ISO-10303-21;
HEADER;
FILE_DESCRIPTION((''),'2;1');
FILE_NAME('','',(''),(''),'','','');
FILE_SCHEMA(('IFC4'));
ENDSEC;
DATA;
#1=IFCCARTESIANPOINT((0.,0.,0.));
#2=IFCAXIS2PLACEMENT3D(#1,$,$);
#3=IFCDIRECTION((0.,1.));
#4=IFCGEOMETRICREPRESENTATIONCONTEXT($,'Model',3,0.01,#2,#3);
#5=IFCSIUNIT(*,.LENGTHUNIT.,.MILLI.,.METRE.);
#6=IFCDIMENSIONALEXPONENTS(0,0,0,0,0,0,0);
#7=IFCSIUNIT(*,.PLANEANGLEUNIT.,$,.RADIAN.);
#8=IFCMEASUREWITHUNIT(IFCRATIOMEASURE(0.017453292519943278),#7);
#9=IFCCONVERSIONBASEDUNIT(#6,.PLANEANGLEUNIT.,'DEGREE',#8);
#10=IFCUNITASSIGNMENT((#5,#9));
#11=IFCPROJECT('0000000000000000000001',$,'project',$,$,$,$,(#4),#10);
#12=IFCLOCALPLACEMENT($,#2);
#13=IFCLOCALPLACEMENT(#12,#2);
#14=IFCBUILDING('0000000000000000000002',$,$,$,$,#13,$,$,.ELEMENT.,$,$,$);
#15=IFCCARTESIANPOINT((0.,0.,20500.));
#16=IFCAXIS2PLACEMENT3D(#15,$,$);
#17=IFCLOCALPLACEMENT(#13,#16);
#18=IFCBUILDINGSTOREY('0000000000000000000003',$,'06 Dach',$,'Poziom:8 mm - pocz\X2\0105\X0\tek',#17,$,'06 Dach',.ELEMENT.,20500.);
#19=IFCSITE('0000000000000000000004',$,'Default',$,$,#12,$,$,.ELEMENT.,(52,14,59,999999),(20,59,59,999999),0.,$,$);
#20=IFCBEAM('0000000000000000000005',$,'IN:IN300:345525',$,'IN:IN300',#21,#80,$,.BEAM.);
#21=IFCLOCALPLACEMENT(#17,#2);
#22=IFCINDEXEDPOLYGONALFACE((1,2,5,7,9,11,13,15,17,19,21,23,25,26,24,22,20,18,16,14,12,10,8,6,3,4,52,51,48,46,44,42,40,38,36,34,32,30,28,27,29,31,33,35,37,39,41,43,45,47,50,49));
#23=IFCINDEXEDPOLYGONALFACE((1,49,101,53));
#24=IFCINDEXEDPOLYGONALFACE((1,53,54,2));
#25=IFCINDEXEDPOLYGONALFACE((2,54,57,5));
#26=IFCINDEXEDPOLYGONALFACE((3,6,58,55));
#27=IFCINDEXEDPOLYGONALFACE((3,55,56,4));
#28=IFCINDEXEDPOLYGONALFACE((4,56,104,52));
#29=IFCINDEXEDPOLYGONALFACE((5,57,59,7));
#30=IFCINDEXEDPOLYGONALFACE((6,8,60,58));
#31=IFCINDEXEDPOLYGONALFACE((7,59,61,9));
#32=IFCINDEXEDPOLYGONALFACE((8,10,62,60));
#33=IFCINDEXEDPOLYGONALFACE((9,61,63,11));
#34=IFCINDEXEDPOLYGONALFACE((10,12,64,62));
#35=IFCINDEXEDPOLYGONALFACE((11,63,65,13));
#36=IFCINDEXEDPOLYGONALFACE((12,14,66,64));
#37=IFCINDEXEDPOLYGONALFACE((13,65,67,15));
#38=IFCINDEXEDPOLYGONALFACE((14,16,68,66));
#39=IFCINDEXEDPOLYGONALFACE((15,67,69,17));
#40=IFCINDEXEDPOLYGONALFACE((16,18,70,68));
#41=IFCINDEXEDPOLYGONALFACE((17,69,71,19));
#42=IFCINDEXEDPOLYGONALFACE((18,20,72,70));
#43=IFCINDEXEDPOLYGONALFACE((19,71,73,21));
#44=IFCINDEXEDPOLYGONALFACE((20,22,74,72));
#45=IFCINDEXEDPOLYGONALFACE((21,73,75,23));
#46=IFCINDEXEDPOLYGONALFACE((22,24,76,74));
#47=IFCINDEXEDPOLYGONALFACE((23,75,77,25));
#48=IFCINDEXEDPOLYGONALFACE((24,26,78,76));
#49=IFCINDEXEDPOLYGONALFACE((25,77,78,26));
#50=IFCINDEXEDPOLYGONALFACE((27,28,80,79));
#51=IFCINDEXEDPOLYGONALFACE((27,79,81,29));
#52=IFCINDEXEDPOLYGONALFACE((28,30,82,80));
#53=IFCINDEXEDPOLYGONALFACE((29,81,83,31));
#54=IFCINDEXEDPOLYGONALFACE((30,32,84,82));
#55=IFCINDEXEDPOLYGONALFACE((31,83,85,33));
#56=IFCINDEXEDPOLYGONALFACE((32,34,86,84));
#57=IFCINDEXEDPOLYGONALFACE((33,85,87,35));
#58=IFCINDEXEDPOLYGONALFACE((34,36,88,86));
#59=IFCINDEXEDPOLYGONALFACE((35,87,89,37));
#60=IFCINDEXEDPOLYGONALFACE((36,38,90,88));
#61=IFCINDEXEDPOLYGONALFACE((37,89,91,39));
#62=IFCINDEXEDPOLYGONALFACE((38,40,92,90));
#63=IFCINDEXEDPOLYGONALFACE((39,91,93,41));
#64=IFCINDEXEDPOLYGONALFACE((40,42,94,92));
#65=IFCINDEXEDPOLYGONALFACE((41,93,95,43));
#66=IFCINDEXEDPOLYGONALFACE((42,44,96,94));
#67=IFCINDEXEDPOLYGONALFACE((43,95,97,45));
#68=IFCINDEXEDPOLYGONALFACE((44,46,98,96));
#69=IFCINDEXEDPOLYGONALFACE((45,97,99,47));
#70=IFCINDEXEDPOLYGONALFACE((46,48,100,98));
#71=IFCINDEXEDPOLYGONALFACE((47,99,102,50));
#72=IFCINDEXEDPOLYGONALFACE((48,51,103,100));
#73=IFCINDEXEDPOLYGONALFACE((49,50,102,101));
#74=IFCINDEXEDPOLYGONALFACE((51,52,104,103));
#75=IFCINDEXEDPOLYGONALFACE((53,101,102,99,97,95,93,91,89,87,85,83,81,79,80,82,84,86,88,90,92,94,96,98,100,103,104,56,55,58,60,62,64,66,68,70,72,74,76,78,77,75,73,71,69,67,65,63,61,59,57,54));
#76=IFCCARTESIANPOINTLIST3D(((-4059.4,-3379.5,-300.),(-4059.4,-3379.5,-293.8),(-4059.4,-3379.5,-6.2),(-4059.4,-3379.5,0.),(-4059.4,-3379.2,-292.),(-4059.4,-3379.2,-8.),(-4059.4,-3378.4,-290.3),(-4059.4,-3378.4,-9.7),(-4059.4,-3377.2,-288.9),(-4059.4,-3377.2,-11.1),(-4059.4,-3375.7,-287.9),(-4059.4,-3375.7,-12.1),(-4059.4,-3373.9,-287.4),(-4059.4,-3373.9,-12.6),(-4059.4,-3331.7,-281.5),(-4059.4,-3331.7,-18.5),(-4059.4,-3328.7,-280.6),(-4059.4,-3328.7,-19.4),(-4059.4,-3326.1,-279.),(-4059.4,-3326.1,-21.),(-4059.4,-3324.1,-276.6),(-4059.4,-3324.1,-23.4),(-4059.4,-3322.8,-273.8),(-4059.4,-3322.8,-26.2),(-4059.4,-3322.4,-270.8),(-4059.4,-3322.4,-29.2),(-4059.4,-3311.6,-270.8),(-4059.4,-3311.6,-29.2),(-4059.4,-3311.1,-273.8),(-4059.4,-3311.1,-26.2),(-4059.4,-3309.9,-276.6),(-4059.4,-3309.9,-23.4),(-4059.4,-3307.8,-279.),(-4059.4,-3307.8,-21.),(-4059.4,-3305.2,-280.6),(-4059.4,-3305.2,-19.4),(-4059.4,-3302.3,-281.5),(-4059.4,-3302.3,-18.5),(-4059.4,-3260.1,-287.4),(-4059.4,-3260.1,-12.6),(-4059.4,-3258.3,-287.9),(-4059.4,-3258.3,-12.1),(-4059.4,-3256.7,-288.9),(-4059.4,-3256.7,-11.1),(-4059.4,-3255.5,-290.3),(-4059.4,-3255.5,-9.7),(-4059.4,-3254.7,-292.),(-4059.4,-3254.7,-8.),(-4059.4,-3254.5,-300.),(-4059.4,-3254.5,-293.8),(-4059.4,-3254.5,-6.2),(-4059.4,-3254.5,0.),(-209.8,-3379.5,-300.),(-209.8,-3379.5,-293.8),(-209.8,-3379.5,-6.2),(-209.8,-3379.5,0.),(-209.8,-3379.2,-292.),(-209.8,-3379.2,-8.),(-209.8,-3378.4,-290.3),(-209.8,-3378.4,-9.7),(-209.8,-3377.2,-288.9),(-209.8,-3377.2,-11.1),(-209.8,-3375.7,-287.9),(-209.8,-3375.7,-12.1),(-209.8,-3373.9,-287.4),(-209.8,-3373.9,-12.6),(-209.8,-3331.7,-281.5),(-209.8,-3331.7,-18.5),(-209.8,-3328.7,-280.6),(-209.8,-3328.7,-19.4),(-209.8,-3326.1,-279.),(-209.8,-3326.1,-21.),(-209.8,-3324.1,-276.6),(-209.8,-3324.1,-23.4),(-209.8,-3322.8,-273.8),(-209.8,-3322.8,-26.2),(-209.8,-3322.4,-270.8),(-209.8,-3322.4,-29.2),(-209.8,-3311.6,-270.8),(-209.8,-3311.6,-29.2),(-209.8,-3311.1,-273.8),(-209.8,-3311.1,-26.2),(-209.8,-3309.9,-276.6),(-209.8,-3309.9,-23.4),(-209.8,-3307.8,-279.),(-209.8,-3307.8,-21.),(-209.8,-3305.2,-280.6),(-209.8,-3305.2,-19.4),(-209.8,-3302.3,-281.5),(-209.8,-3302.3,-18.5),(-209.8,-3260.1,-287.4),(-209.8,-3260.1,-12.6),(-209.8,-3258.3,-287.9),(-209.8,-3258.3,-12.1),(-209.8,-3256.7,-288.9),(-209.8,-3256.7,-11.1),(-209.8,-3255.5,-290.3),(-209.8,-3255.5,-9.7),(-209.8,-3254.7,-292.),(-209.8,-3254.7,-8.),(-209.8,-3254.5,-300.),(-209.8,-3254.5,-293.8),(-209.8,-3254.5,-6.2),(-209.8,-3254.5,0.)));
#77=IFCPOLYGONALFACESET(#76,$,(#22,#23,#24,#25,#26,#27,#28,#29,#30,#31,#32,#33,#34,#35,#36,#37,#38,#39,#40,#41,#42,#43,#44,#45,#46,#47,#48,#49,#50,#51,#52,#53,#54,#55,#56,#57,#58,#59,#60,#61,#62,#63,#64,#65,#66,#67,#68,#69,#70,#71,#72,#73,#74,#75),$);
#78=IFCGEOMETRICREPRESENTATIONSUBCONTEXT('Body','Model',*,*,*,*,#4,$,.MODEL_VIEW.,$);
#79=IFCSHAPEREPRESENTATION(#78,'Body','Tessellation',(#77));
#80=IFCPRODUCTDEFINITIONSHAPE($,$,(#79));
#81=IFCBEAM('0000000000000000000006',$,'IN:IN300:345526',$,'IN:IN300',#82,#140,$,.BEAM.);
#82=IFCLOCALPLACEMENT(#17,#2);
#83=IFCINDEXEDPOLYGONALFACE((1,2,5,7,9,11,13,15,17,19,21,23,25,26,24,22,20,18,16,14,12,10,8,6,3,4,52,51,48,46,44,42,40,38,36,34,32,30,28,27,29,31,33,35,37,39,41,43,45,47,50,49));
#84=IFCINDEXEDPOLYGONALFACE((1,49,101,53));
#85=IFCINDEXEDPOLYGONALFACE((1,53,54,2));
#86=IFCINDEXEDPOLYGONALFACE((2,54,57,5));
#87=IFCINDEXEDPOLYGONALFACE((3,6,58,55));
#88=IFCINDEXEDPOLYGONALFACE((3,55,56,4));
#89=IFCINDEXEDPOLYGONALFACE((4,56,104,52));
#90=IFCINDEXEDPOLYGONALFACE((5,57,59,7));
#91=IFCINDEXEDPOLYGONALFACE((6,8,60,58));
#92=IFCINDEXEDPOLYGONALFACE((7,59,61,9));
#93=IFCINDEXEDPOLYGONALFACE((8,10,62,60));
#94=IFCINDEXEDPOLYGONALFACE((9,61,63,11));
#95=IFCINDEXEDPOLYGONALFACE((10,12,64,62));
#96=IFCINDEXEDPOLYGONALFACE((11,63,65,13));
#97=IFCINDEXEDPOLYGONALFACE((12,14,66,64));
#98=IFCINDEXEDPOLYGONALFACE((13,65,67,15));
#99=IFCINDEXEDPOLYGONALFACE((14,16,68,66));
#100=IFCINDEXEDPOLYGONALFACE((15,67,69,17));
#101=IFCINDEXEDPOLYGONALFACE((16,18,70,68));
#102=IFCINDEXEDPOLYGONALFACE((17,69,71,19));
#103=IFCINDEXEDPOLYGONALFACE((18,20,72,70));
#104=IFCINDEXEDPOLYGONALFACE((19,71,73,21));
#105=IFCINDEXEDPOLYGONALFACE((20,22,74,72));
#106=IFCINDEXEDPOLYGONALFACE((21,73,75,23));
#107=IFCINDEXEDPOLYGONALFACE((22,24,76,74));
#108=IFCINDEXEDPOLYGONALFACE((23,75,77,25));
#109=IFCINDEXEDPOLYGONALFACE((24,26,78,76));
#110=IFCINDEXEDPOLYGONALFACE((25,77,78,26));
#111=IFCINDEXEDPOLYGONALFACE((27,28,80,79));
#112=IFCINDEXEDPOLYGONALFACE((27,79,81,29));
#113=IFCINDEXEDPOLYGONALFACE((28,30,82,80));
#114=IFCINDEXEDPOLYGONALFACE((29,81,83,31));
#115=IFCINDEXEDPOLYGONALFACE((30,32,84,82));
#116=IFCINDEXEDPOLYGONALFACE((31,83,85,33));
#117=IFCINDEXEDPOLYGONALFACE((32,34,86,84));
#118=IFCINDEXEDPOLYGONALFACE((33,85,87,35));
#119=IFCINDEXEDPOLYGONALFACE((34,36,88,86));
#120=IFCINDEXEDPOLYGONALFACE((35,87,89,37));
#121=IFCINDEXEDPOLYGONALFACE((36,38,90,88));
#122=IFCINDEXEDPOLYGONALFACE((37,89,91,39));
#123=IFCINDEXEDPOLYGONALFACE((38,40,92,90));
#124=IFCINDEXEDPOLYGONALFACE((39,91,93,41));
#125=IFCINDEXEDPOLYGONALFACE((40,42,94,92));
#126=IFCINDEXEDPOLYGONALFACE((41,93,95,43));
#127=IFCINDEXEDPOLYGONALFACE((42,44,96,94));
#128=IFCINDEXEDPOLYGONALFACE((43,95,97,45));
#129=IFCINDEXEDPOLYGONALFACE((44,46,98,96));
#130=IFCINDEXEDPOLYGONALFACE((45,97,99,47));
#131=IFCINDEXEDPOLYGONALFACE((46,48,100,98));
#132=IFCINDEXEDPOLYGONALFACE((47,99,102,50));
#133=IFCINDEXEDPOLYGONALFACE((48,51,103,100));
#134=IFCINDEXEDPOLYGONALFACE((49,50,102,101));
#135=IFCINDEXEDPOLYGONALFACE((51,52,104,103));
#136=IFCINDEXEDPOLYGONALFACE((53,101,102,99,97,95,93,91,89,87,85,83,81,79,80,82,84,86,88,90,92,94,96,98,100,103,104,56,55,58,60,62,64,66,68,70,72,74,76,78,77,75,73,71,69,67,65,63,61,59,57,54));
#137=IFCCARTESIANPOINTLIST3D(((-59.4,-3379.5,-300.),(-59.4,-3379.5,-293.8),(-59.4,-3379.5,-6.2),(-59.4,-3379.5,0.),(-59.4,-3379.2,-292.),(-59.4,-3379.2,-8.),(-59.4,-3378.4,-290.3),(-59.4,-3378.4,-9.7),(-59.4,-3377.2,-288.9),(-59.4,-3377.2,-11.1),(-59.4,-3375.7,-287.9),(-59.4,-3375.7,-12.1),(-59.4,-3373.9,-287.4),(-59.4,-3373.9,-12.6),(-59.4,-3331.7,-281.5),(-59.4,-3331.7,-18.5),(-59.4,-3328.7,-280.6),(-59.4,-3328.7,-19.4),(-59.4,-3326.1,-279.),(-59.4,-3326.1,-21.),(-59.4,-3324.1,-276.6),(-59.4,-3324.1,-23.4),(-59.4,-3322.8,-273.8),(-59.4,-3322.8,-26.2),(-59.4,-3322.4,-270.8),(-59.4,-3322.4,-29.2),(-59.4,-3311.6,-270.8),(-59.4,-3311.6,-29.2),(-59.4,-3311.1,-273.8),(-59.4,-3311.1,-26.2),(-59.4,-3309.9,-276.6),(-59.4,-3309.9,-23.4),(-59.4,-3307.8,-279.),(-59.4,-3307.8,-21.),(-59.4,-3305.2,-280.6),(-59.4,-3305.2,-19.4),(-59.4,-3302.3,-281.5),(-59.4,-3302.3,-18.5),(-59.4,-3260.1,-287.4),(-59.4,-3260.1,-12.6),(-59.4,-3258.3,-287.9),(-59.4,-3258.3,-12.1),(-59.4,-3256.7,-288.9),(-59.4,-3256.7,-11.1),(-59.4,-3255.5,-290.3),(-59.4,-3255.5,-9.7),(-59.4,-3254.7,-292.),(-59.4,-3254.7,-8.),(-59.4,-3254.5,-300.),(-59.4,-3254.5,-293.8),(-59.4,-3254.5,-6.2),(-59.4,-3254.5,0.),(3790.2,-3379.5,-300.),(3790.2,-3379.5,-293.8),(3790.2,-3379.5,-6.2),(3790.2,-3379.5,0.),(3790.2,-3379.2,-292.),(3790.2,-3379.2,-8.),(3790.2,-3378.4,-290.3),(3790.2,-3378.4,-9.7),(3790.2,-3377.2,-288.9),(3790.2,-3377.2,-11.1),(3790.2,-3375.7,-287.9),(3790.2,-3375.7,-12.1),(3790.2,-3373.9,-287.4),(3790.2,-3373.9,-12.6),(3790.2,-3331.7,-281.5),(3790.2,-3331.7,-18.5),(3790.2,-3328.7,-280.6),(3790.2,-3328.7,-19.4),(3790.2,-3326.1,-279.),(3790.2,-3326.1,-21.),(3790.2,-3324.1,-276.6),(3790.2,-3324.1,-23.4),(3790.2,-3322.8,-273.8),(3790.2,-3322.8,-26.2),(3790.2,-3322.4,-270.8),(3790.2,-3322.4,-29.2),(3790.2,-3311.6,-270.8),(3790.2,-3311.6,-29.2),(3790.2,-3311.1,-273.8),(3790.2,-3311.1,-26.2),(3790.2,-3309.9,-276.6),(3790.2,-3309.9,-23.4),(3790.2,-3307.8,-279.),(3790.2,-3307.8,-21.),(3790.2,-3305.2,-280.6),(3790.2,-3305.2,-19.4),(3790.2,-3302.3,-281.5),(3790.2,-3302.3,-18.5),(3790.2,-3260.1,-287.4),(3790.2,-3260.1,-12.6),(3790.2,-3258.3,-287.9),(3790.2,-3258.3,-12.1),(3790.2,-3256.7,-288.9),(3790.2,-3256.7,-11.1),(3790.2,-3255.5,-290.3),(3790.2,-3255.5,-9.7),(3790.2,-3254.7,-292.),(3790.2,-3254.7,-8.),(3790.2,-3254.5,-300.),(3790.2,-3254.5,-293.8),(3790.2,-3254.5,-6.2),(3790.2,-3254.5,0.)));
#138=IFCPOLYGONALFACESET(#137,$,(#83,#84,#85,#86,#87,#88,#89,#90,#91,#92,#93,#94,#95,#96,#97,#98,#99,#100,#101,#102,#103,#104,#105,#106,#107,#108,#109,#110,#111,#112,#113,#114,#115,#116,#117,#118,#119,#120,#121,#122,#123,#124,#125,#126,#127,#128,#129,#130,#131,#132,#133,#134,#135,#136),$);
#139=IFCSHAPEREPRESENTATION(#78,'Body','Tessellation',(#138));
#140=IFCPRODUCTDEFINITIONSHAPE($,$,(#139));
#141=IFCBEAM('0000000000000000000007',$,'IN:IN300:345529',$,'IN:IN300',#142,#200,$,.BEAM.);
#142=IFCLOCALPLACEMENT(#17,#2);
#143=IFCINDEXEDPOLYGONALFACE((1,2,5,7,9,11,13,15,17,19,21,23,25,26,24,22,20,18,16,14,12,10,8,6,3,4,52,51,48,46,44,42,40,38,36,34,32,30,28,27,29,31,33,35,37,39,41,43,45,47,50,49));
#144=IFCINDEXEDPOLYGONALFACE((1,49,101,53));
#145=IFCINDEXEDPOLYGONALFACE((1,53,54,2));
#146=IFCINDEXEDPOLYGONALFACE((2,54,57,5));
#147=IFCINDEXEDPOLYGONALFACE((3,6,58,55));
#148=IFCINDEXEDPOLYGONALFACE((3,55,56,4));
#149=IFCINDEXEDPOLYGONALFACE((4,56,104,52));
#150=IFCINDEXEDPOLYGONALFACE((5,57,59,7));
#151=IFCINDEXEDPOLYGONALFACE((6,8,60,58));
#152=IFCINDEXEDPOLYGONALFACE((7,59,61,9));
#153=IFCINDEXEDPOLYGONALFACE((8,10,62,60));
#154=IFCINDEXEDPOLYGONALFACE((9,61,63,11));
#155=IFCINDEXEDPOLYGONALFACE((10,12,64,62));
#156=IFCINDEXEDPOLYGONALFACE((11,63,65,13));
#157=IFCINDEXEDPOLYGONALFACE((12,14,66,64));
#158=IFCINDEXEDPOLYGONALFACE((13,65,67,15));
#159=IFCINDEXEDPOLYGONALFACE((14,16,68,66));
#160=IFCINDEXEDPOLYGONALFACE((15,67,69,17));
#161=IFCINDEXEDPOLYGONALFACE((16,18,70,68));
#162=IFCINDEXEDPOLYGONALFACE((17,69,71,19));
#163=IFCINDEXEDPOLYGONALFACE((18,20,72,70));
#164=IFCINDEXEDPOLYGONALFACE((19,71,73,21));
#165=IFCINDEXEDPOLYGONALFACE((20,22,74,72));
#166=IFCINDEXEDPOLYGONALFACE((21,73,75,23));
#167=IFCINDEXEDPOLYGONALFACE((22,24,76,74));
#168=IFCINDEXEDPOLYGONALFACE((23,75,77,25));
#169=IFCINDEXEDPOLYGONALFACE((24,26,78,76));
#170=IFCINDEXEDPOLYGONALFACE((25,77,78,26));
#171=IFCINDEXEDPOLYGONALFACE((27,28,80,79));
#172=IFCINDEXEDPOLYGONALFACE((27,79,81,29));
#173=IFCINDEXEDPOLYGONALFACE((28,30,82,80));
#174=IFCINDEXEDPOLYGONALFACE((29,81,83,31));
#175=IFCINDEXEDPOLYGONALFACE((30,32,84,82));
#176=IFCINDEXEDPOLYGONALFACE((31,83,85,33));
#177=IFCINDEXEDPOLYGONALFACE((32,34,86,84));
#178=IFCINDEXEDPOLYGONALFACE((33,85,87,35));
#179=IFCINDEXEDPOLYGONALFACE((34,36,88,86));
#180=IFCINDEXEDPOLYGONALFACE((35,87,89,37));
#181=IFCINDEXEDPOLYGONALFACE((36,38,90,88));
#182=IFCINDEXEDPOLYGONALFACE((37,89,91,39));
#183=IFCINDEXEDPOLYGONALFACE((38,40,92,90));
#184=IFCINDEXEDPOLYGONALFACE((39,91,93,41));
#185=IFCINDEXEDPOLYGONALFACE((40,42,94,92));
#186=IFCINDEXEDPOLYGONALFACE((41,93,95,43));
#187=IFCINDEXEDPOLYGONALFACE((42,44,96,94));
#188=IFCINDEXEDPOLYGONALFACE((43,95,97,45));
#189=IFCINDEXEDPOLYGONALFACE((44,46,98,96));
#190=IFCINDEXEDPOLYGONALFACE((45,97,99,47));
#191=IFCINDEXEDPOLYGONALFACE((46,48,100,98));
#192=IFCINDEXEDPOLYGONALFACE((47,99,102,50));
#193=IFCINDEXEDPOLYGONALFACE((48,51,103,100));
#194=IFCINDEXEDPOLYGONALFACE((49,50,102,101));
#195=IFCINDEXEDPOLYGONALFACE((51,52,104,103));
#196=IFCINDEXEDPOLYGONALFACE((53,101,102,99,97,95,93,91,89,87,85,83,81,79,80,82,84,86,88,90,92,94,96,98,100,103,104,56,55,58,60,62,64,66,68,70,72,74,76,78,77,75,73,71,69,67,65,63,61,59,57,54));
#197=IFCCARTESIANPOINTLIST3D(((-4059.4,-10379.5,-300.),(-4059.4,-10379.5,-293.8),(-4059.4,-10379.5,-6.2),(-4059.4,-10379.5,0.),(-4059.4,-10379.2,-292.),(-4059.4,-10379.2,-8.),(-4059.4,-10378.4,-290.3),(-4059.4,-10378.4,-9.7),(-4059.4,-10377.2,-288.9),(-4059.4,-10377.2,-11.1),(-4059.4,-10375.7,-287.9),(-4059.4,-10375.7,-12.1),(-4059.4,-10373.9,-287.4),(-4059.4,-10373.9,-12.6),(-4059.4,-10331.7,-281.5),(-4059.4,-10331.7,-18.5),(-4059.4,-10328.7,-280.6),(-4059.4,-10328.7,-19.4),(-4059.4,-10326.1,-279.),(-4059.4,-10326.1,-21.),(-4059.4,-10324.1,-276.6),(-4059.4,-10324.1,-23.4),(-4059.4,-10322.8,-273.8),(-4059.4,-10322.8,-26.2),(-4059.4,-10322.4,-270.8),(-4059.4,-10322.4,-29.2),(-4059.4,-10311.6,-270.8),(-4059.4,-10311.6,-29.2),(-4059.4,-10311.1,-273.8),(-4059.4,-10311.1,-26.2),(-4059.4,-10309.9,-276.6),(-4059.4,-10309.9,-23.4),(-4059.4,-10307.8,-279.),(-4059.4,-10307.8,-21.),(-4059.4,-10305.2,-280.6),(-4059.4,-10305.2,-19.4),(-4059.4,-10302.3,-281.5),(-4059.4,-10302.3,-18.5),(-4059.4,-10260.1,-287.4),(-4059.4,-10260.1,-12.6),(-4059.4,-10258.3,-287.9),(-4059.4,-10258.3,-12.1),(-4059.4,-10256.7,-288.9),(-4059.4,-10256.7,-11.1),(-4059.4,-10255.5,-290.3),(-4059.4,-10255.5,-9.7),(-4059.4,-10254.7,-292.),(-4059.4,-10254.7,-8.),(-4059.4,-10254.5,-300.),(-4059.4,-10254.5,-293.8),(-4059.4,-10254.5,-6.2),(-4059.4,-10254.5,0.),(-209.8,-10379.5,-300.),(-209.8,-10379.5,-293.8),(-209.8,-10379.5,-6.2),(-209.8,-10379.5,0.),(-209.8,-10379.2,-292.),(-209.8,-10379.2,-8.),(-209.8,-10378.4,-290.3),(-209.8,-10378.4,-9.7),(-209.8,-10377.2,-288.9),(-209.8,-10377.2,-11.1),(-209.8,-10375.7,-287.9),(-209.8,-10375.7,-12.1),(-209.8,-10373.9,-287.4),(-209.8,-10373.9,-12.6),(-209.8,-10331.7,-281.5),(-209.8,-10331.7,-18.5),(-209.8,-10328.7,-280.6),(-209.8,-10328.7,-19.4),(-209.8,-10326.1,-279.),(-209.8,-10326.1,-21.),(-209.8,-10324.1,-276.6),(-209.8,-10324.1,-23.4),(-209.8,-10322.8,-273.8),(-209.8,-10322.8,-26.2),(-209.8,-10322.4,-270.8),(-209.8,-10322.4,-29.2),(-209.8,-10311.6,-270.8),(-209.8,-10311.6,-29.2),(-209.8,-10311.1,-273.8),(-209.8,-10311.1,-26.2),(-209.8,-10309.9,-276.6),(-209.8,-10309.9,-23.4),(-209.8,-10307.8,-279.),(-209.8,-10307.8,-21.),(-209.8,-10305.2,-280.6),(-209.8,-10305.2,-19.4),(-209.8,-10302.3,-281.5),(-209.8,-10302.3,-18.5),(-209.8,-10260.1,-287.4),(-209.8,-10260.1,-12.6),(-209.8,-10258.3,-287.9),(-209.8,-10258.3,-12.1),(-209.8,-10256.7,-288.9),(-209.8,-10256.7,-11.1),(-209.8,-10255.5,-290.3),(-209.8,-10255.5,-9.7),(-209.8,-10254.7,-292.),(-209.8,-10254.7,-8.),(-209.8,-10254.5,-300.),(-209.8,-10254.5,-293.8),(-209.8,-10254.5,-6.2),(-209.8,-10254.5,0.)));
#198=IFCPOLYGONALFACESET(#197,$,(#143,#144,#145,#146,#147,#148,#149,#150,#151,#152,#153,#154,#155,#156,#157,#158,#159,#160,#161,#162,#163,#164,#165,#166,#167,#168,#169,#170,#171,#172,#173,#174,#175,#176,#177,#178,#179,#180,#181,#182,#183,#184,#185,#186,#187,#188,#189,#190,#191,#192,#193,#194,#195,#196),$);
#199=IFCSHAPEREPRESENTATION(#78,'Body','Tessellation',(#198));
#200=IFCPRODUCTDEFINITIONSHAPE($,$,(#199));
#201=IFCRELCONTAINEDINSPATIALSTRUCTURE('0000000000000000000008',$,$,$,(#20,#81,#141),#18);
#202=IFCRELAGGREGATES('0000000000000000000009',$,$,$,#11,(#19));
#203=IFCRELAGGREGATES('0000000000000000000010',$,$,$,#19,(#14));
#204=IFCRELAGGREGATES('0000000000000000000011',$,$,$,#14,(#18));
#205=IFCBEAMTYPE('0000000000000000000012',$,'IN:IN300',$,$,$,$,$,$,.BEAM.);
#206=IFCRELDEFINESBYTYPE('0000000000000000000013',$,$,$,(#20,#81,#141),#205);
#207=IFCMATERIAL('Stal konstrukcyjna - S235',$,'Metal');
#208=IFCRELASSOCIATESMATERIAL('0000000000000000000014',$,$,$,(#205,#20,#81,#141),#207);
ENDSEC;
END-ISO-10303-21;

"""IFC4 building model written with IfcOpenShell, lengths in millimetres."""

from ifc_helpers import new_model, entity, si_unit, converted_unit, direction, frame, origin, place, context, subcontext, project, spatial, line, arc, indexed_curve, outline, extrude, source, transform, mapped, material, type_object, type_shapes, element, save


model = new_model("IFC4")

# Units and contexts
model_context = context("Model", 3, precision=0.01, world=origin(), true_north=direction((0.0, 1.0)))
body_context = subcontext(model_context, "Body", "Model", "MODEL_VIEW")
ifc_project = project(units=[si_unit("LENGTHUNIT", "METRE", prefix="MILLI"), converted_unit("PLANEANGLEUNIT", "DEGREE", entity("IfcRatioMeasure", 0.017453292519943278), si_unit("PLANEANGLEUNIT", "RADIAN"), dimensions=[0, 0, 0, 0, 0, 0, 0])], contexts=[model_context])

# Site, building, storey
site_placement = place(None, origin())
site = spatial("IfcSite", under=ifc_project, at=site_placement, Name="Default", CompositionType="ELEMENT", RefLatitude=(52, 14, 59, 999999), RefLongitude=(20, 59, 59, 999999), RefElevation=0.0)
building_placement = place(site_placement, origin())
building = spatial("IfcBuilding", under=site, at=building_placement, CompositionType="ELEMENT")
storey_placement = place(building_placement, frame((0.0, 0.0, 20500.0)))
storey = spatial("IfcBuildingStorey", under=building, at=storey_placement, Name="06 Dach", ObjectType="Poziom:8 mm - początek", LongName="06 Dach", CompositionType="ELEMENT", Elevation=20500.0)

# Beams
ifc_material_1 = material(Name="Stal konstrukcyjna - S235", Category="Metal")
beam_type_1 = type_object("IfcBeamType", Name="IN:IN300", PredefinedType="BEAM", material=ifc_material_1)
shared_shape_1 = source(origin(), body_context, "Body", "SweptSolid", [
    extrude(outline(indexed_curve([(143.8, -62.5), (150.0, -62.5), (150.0, 62.5), (143.8, 62.5), (139.6, 60.9), (137.4, 56.9), (131.5, 14.7), (127.9, 8.1), (120.8, 5.4), (-120.8, 5.4), (-127.9, 8.1), (-131.5, 14.7), (-137.4, 56.9), (-139.6, 60.9), (-143.8, 62.5), (-150.0, 62.5), (-150.0, -62.5), (-143.8, -62.5), (-139.6, -60.9), (-137.4, -56.9), (-131.5, -14.7), (-127.9, -8.1), (-120.8, -5.4), (120.8, -5.4), (127.9, -8.1), (131.5, -14.7), (137.4, -56.9), (139.6, -60.9)], segments=[line(1, 2, 3, 4), arc(4, 5, 6), line(6, 7), arc(7, 8, 9), line(9, 10), arc(10, 11, 12), line(12, 13), arc(13, 14, 15), line(15, 16, 17, 18), arc(18, 19, 20), line(20, 21), arc(21, 22, 23), line(23, 24), arc(24, 25, 26), line(26, 27), arc(27, 28, 1)], self_intersect=False)), frame((-1924.8, 0.0, 0.0), z_axis=(1.0, 0.0, 0.0), x_axis=(0.0, 0.0, -1.0)), (0.0, 0.0, 1.0), 3849.6),
])
type_shapes(beam_type_1, [shared_shape_1])
for number, where, name in (
    (1, (-2134.6, -3317.0, -150.0), "IN:IN300:345525"),
    (2, (1865.4, -3317.0, -150.0), "IN:IN300:345526"),
    (3, (-2134.6, -10317.0, -150.0), "IN:IN300:345529"),
):
    element("IfcBeam", number, at=place(storey_placement, frame(where)), inside=storey, type_object=beam_type_1, material=ifc_material_1, Name=name, ObjectType="IN:IN300", PredefinedType="BEAM", context=body_context, shape_type="MappedRepresentation", body=[
        mapped(shared_shape_1, transform((0.0, 0.0, 0.0), scale=1.0)),
    ])

save(model, "model.ifc")
